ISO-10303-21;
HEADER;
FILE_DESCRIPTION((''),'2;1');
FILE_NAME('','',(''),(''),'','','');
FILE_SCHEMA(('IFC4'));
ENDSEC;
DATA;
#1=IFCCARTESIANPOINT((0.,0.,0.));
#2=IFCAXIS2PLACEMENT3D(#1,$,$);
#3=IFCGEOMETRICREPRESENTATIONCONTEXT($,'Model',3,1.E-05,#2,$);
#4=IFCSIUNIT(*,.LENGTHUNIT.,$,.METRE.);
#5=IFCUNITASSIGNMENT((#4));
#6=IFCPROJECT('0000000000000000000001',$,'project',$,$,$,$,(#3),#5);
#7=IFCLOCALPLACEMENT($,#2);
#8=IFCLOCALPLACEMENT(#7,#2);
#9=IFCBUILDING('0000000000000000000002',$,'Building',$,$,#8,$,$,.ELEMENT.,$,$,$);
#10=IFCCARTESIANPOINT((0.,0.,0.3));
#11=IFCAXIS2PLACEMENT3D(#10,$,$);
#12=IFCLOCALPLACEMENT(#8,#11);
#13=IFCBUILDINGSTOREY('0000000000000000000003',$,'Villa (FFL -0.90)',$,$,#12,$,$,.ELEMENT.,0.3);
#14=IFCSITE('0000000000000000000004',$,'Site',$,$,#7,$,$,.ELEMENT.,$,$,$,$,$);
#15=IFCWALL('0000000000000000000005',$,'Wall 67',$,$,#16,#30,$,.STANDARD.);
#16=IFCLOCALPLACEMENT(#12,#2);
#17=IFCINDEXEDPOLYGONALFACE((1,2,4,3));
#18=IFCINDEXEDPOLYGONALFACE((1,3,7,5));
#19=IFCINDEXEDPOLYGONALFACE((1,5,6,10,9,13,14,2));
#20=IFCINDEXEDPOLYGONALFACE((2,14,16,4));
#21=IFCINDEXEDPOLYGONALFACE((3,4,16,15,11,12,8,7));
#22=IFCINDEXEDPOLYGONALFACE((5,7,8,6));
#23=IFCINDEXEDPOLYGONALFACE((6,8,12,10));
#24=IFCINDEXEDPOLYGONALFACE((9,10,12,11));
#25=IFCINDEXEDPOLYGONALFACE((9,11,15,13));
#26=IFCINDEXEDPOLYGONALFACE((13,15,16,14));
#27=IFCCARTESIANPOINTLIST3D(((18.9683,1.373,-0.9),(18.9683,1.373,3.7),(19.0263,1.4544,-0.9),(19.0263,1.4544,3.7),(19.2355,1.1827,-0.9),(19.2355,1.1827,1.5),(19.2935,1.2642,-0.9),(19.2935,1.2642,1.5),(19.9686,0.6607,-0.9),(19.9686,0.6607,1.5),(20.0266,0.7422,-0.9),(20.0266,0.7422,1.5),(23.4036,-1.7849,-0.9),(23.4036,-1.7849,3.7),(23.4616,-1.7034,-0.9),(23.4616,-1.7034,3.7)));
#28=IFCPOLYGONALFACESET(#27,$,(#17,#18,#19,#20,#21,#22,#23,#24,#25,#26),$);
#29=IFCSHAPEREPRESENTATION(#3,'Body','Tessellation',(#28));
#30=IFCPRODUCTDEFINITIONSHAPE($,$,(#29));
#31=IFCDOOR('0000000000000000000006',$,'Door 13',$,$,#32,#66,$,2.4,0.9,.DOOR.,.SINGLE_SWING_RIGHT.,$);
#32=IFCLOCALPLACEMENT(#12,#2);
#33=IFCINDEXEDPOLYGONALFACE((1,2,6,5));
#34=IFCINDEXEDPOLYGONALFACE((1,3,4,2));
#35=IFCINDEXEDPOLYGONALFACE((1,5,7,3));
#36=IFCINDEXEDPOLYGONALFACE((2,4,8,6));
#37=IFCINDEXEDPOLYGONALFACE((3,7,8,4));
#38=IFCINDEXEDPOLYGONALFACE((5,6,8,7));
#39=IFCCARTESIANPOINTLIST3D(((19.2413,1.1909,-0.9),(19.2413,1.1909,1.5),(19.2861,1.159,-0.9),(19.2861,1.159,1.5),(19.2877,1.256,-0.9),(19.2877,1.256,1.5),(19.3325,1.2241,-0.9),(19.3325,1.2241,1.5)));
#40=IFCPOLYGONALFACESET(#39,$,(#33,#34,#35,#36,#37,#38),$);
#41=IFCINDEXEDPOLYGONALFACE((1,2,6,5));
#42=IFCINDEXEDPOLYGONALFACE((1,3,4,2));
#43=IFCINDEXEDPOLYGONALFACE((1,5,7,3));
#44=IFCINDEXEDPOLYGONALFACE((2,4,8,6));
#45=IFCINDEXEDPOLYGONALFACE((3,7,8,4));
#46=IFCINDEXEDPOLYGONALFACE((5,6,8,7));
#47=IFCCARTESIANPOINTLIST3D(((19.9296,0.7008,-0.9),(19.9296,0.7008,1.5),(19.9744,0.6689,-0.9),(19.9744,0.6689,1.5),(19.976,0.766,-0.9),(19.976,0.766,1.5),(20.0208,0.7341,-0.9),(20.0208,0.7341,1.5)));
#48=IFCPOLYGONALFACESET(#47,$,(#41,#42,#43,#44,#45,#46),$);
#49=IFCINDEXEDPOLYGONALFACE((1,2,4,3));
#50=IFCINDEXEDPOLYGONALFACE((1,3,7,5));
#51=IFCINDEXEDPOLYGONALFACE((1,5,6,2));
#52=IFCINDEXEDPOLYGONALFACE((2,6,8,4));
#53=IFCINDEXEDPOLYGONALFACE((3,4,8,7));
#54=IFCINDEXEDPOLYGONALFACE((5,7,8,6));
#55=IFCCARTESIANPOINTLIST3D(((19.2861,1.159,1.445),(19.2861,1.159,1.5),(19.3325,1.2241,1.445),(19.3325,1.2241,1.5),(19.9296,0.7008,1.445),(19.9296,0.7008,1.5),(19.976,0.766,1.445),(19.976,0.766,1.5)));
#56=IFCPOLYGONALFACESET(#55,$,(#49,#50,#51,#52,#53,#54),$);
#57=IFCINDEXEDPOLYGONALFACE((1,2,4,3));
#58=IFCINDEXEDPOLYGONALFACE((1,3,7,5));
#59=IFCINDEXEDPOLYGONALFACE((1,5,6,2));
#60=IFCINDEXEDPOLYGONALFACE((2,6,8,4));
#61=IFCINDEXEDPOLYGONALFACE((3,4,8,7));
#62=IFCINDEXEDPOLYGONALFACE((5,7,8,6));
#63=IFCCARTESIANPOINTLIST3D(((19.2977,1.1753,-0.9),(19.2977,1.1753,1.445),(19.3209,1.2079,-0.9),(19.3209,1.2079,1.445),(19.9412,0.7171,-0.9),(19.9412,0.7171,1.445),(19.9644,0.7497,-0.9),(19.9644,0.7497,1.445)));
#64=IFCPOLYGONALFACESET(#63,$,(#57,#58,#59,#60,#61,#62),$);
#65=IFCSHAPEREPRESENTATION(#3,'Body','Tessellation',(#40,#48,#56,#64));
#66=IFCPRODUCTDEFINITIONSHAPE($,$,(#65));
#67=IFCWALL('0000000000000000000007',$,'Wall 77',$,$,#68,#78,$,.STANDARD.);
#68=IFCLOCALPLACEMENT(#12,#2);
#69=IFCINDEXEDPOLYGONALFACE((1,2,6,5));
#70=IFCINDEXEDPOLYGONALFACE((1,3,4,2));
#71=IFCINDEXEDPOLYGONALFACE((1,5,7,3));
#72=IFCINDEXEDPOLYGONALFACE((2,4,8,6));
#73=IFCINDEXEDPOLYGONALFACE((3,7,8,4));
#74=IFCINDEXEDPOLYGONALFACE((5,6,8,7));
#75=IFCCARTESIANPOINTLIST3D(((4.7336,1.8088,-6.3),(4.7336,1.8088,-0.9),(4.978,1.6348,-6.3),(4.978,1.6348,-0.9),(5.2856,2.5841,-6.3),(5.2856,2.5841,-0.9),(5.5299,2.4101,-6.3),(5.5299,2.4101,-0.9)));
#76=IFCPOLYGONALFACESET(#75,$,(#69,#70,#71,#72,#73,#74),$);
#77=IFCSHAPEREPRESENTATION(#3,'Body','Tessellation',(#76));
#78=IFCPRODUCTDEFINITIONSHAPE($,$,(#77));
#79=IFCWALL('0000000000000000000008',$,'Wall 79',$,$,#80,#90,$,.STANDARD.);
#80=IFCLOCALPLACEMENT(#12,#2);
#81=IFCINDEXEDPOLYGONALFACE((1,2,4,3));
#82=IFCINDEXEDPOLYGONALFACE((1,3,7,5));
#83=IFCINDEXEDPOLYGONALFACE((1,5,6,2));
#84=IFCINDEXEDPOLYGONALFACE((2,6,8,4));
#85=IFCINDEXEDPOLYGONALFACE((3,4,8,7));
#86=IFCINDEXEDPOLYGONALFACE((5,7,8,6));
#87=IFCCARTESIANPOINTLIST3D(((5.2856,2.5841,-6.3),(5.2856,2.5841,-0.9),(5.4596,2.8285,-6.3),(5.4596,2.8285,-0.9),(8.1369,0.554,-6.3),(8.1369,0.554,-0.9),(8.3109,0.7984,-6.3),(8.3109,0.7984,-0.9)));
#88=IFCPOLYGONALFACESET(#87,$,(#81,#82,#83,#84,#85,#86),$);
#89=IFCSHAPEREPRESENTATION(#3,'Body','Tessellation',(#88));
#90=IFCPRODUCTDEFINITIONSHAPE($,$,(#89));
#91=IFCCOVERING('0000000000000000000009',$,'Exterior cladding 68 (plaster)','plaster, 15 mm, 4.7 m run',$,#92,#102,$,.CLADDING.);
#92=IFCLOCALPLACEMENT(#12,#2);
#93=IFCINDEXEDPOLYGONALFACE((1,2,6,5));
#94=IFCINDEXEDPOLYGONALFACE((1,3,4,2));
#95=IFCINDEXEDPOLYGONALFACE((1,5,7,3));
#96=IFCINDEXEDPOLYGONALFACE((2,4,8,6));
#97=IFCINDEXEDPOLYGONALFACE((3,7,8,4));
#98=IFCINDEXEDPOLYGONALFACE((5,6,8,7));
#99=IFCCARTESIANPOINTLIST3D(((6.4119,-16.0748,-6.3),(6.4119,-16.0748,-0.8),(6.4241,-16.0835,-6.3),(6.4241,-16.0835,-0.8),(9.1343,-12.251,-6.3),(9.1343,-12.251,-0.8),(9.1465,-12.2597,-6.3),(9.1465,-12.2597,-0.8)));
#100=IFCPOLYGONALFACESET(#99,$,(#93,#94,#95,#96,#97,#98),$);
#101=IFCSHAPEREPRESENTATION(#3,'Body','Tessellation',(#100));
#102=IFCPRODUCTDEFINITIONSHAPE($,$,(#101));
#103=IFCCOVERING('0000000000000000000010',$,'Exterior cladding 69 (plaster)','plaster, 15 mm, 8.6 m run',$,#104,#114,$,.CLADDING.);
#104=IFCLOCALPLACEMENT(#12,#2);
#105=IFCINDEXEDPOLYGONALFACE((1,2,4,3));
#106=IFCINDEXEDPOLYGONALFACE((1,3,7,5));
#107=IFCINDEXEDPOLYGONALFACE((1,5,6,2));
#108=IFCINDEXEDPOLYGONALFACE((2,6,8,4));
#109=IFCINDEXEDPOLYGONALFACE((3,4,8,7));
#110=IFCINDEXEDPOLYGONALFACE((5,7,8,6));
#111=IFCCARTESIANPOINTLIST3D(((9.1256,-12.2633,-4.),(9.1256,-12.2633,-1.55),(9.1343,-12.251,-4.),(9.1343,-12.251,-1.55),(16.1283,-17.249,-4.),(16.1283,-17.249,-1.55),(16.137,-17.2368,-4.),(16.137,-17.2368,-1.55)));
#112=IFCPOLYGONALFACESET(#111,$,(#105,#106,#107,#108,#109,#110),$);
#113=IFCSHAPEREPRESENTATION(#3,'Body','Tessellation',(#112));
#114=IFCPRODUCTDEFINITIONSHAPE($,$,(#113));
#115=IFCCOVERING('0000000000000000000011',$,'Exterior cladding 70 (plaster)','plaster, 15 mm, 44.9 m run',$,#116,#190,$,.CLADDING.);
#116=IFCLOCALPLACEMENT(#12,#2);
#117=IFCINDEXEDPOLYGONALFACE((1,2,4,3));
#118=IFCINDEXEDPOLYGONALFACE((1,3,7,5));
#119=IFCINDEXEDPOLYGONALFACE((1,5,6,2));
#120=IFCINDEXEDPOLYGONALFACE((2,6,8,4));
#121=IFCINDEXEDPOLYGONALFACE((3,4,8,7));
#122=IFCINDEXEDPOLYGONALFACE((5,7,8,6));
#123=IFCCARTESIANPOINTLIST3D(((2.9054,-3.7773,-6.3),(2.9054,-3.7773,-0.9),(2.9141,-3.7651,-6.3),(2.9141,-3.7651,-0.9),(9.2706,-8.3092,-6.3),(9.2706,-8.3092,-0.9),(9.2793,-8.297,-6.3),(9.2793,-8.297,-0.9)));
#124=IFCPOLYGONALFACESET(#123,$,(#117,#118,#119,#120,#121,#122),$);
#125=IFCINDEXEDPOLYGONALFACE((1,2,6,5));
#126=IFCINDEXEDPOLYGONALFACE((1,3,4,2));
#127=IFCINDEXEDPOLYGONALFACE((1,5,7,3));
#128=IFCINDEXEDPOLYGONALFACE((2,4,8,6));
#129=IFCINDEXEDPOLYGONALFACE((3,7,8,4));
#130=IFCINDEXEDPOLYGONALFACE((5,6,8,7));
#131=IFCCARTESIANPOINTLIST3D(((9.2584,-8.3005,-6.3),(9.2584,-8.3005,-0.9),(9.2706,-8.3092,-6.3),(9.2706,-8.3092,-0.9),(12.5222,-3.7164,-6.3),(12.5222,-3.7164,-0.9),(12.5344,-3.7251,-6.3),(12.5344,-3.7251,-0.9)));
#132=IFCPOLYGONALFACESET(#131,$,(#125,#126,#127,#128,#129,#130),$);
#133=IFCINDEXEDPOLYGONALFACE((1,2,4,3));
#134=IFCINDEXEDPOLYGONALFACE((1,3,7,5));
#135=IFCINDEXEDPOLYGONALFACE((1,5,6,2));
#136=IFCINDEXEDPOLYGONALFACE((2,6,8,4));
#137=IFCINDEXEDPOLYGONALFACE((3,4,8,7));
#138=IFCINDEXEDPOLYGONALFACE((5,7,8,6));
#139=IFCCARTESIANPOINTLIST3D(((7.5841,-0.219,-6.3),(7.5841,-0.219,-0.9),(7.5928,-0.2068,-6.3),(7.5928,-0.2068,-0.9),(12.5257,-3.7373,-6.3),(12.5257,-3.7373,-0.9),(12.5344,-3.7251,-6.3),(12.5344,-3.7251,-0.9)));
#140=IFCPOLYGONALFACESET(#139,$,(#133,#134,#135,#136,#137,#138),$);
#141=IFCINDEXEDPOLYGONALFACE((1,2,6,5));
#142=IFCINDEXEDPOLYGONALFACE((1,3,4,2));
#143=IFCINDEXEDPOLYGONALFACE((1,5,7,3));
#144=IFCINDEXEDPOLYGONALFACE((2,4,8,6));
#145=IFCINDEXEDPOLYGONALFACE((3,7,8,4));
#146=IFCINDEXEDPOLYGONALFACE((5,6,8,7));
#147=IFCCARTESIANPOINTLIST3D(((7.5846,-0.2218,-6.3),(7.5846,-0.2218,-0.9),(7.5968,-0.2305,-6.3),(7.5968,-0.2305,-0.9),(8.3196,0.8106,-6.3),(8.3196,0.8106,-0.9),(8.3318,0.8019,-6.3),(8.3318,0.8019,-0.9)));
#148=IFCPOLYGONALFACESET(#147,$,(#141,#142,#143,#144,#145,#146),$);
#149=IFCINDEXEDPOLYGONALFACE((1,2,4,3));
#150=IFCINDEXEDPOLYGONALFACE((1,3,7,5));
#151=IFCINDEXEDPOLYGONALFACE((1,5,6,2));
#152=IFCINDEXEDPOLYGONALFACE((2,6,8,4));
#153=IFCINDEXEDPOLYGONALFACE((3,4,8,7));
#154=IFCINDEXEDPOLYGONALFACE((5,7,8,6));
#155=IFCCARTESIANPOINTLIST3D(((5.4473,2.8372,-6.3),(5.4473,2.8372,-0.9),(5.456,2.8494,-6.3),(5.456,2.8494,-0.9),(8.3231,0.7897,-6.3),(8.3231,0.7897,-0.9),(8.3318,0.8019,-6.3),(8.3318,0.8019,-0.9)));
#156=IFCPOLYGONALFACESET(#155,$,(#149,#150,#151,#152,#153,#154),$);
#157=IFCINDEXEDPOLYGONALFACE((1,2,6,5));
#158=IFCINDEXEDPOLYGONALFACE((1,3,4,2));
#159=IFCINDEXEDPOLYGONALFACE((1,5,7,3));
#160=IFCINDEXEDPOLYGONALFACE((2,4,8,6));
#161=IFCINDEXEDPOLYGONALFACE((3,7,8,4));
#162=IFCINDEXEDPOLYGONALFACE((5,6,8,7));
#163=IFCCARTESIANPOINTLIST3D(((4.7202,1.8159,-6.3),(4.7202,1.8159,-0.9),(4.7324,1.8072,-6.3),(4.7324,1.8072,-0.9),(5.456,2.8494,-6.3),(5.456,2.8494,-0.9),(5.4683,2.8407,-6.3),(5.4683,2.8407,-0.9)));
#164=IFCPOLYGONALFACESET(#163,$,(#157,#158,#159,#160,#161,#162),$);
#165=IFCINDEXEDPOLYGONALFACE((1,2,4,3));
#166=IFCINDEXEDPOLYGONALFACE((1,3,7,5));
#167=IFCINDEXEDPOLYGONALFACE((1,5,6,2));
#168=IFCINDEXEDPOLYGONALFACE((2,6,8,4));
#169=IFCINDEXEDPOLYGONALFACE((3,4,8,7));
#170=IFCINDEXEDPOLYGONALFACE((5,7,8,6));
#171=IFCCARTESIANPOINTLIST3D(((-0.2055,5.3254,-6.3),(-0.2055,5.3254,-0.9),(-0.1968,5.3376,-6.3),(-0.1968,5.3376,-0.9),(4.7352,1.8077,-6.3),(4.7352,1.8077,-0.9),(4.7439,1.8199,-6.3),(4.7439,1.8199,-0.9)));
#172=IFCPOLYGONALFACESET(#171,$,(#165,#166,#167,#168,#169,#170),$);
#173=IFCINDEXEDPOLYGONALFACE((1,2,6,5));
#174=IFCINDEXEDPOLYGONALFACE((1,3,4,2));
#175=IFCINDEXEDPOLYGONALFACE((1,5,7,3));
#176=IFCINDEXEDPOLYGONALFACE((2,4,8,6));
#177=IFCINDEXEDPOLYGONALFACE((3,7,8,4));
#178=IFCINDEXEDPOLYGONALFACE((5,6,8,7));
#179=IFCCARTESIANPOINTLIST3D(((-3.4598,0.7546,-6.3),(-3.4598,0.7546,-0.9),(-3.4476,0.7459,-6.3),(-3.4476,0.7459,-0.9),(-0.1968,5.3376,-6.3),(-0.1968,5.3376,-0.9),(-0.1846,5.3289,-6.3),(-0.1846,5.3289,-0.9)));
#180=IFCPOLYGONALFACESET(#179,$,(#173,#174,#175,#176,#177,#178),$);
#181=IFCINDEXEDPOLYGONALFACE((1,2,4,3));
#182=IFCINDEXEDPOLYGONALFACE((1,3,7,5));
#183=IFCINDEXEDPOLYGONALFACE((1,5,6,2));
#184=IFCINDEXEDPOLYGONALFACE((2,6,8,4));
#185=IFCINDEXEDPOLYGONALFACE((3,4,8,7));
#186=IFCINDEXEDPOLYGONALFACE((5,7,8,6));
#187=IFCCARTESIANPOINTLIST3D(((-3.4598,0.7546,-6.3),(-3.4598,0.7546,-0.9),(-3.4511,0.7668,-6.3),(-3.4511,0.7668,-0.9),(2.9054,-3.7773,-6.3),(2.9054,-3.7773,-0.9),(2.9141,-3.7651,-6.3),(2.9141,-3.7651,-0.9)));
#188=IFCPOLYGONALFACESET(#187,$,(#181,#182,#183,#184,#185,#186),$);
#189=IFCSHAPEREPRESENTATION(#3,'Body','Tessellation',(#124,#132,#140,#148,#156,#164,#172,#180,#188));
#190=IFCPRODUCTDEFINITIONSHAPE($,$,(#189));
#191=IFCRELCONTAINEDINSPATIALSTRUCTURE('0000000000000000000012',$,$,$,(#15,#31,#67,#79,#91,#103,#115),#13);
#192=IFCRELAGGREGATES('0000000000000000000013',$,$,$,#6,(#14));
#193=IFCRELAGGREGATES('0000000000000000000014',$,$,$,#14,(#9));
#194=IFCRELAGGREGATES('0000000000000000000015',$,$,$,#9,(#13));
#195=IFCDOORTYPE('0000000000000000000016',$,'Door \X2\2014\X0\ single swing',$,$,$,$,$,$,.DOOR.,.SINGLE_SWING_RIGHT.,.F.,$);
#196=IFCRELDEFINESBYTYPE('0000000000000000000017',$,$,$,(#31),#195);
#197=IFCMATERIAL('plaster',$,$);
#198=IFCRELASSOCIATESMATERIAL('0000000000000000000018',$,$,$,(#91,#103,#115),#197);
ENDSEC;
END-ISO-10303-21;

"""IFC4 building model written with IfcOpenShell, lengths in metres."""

from ifc_helpers import new_model, si_unit, frame, frame_2d, origin, origin_with_axes, place, context, project, spatial, polyline, rectangle, outline, extrude, material, type_object, element, fill, save


model = new_model("IFC4")

# Units and contexts
model_context = context("Model", 3, precision=1e-05, world=origin())
ifc_project = project(units=[si_unit("LENGTHUNIT", "METRE")], contexts=[model_context])

# Site, building, storey
site_placement = place(None, origin())
site = spatial("IfcSite", under=ifc_project, at=site_placement, Name="Site", CompositionType="ELEMENT")
building_placement = place(site_placement, origin())
building = spatial("IfcBuilding", under=site, at=building_placement, Name="Building", CompositionType="ELEMENT")
storey_placement = place(building_placement, frame((0.0, 0.0, 0.3)))
storey = spatial("IfcBuildingStorey", under=building, at=storey_placement, Name="Villa (FFL -0.90)", CompositionType="ELEMENT", Elevation=0.3)

# Shared definitions
door_type_1 = type_object("IfcDoorType", Name="Door — single swing", OperationType="SINGLE_SWING_RIGHT", ParameterTakesPrecedence=False, PredefinedType="DOOR")

# Wall, opening, door
wall_1_placement = place(storey_placement, frame((18.9973, 1.4137, -0.9), z_axis=(0.0, 0.0, 1.0), x_axis=(0.814622, -0.579992, 0.0)))
wall_1 = element("IfcWall", 1, at=wall_1_placement, inside=storey, Name="Wall 67", PredefinedType="STANDARD", context=model_context, shape_type="SweptSolid", body=[
    extrude(rectangle(XDim=5.4446, YDim=0.1, at=frame_2d((2.7223, 0.0))), origin(), (0.0, 0.0, 1.0), 4.6),
])
opening_1_placement = place(storey_placement, frame((19.2645, 1.2235, -0.9), z_axis=(0.0, 0.0, 1.0), x_axis=(0.814622, -0.579992, 0.0)))
opening_1 = element("IfcOpeningElement", 2, at=opening_1_placement, cuts=wall_1, PredefinedType="OPENING", context=model_context, shape_type="SweptSolid", body=[
    extrude(rectangle(XDim=0.9, YDim=0.16, at=frame_2d((0.45, 0.0))), origin(), (0.0, 0.0, 1.0), 2.4),
])
door_1_placement = place(storey_placement, frame((19.2645, 1.2235, -0.9), z_axis=(0.0, 0.0, 1.0), x_axis=(0.814622, -0.579992, 0.0)))
door_1 = element("IfcDoor", 3, at=door_1_placement, inside=storey, type_object=door_type_1, Name="Door 13", OperationType="SINGLE_SWING_RIGHT", OverallHeight=2.4, OverallWidth=0.9, PredefinedType="DOOR", context=model_context, shape_type="SweptSolid", body=[
    extrude(rectangle(XDim=0.055, YDim=0.08, at=frame_2d((0.0275, 0.0))), origin(), (0.0, 0.0, 1.0), 2.4),
    extrude(rectangle(XDim=0.055, YDim=0.08, at=frame_2d((0.8725, 0.0))), origin(), (0.0, 0.0, 1.0), 2.4),
    extrude(rectangle(XDim=0.79, YDim=0.08, at=frame_2d((0.45, 0.0))), frame((0.0, 0.0, 2.345)), (0.0, 0.0, 1.0), 0.055),
    extrude(rectangle(XDim=0.79, YDim=0.04, at=frame_2d((0.45, 0.0))), origin(), (0.0, 0.0, 1.0), 2.345),
])
fill(opening_1, door_1)

# Walls
wall_2_placement = place(storey_placement, frame((4.8558, 1.7218, -6.3), z_axis=(0.0, 0.0, 1.0), x_axis=(0.579992, 0.814622, 0.0)))
element("IfcWall", 4, at=wall_2_placement, inside=storey, Name="Wall 77", PredefinedType="STANDARD", context=model_context, shape_type="SweptSolid", body=[
    extrude(rectangle(XDim=0.9517, YDim=0.3, at=frame_2d((0.4758, 0.0))), origin(), (0.0, 0.0, 1.0), 5.4),
])
wall_3_placement = place(storey_placement, frame((8.2239, 0.6762, -6.3), z_axis=(0.0, 0.0, 1.0), x_axis=(-0.814622, 0.579992, 0.0)))
element("IfcWall", 5, at=wall_3_placement, inside=storey, Name="Wall 79", PredefinedType="STANDARD", context=model_context, shape_type="SweptSolid", body=[
    extrude(rectangle(XDim=3.5002, YDim=0.3, at=frame_2d((1.7501, 0.0))), origin(), (0.0, 0.0, 1.0), 5.4),
])

# Coverings
ifc_material = material(Name="plaster")
covering_1_placement = place(storey_placement, origin_with_axes())
element("IfcCovering", 6, at=covering_1_placement, inside=storey, material=ifc_material, Name="Exterior cladding 68 (plaster)", Description="plaster, 15 mm, 4.7 m run", PredefinedType="CLADDING", context=model_context, shape_type="SweptSolid", body=[
    extrude(outline(polyline([(6.4241, -16.0835), (9.1465, -12.2597), (9.1343, -12.251), (6.4119, -16.0748), (6.4241, -16.0835)])), frame((0.0, 0.0, -6.3)), (0.0, 0.0, 1.0), 5.5),
])
covering_2_placement = place(storey_placement, origin_with_axes())
element("IfcCovering", 7, at=covering_2_placement, inside=storey, material=ifc_material, Name="Exterior cladding 69 (plaster)", Description="plaster, 15 mm, 8.6 m run", PredefinedType="CLADDING", context=model_context, shape_type="SweptSolid", body=[
    extrude(outline(polyline([(9.1256, -12.2633), (16.1283, -17.249), (16.137, -17.2368), (9.1343, -12.251), (9.1256, -12.2633)])), frame((0.0, 0.0, -4.0)), (0.0, 0.0, 1.0), 2.45),
])
covering_3_placement = place(storey_placement, origin_with_axes())
element("IfcCovering", 8, at=covering_3_placement, inside=storey, material=ifc_material, Name="Exterior cladding 70 (plaster)", Description="plaster, 15 mm, 44.9 m run", PredefinedType="CLADDING", context=model_context, shape_type="SweptSolid", body=[
    extrude(outline(polyline([(2.9054, -3.7773), (9.2706, -8.3092), (9.2793, -8.297), (2.9141, -3.7651), (2.9054, -3.7773)])), frame((0.0, 0.0, -6.3)), (0.0, 0.0, 1.0), 5.4),
    extrude(outline(polyline([(9.2706, -8.3092), (12.5344, -3.7251), (12.5222, -3.7164), (9.2584, -8.3005), (9.2706, -8.3092)])), frame((0.0, 0.0, -6.3)), (0.0, 0.0, 1.0), 5.4),
    extrude(outline(polyline([(12.5344, -3.7251), (7.5928, -0.2068), (7.5841, -0.219), (12.5257, -3.7373), (12.5344, -3.7251)])), frame((0.0, 0.0, -6.3)), (0.0, 0.0, 1.0), 5.4),
    extrude(outline(polyline([(7.5968, -0.2305), (8.3318, 0.8019), (8.3196, 0.8106), (7.5846, -0.2218), (7.5968, -0.2305)])), frame((0.0, 0.0, -6.3)), (0.0, 0.0, 1.0), 5.4),
    extrude(outline(polyline([(8.3318, 0.8019), (5.456, 2.8494), (5.4473, 2.8372), (8.3231, 0.7897), (8.3318, 0.8019)])), frame((0.0, 0.0, -6.3)), (0.0, 0.0, 1.0), 5.4),
    extrude(outline(polyline([(5.456, 2.8494), (4.7202, 1.8159), (4.7324, 1.8072), (5.4683, 2.8407), (5.456, 2.8494)])), frame((0.0, 0.0, -6.3)), (0.0, 0.0, 1.0), 5.4),
    extrude(outline(polyline([(4.7439, 1.8199), (-0.1968, 5.3376), (-0.2055, 5.3254), (4.7352, 1.8077), (4.7439, 1.8199)])), frame((0.0, 0.0, -6.3)), (0.0, 0.0, 1.0), 5.4),
    extrude(outline(polyline([(-0.1968, 5.3376), (-3.4598, 0.7546), (-3.4476, 0.7459), (-0.1846, 5.3289), (-0.1968, 5.3376)])), frame((0.0, 0.0, -6.3)), (0.0, 0.0, 1.0), 5.4),
    extrude(outline(polyline([(-3.4598, 0.7546), (2.9054, -3.7773), (2.9141, -3.7651), (-3.4511, 0.7668), (-3.4598, 0.7546)])), frame((0.0, 0.0, -6.3)), (0.0, 0.0, 1.0), 5.4),
])

save(model, "model.ifc")
